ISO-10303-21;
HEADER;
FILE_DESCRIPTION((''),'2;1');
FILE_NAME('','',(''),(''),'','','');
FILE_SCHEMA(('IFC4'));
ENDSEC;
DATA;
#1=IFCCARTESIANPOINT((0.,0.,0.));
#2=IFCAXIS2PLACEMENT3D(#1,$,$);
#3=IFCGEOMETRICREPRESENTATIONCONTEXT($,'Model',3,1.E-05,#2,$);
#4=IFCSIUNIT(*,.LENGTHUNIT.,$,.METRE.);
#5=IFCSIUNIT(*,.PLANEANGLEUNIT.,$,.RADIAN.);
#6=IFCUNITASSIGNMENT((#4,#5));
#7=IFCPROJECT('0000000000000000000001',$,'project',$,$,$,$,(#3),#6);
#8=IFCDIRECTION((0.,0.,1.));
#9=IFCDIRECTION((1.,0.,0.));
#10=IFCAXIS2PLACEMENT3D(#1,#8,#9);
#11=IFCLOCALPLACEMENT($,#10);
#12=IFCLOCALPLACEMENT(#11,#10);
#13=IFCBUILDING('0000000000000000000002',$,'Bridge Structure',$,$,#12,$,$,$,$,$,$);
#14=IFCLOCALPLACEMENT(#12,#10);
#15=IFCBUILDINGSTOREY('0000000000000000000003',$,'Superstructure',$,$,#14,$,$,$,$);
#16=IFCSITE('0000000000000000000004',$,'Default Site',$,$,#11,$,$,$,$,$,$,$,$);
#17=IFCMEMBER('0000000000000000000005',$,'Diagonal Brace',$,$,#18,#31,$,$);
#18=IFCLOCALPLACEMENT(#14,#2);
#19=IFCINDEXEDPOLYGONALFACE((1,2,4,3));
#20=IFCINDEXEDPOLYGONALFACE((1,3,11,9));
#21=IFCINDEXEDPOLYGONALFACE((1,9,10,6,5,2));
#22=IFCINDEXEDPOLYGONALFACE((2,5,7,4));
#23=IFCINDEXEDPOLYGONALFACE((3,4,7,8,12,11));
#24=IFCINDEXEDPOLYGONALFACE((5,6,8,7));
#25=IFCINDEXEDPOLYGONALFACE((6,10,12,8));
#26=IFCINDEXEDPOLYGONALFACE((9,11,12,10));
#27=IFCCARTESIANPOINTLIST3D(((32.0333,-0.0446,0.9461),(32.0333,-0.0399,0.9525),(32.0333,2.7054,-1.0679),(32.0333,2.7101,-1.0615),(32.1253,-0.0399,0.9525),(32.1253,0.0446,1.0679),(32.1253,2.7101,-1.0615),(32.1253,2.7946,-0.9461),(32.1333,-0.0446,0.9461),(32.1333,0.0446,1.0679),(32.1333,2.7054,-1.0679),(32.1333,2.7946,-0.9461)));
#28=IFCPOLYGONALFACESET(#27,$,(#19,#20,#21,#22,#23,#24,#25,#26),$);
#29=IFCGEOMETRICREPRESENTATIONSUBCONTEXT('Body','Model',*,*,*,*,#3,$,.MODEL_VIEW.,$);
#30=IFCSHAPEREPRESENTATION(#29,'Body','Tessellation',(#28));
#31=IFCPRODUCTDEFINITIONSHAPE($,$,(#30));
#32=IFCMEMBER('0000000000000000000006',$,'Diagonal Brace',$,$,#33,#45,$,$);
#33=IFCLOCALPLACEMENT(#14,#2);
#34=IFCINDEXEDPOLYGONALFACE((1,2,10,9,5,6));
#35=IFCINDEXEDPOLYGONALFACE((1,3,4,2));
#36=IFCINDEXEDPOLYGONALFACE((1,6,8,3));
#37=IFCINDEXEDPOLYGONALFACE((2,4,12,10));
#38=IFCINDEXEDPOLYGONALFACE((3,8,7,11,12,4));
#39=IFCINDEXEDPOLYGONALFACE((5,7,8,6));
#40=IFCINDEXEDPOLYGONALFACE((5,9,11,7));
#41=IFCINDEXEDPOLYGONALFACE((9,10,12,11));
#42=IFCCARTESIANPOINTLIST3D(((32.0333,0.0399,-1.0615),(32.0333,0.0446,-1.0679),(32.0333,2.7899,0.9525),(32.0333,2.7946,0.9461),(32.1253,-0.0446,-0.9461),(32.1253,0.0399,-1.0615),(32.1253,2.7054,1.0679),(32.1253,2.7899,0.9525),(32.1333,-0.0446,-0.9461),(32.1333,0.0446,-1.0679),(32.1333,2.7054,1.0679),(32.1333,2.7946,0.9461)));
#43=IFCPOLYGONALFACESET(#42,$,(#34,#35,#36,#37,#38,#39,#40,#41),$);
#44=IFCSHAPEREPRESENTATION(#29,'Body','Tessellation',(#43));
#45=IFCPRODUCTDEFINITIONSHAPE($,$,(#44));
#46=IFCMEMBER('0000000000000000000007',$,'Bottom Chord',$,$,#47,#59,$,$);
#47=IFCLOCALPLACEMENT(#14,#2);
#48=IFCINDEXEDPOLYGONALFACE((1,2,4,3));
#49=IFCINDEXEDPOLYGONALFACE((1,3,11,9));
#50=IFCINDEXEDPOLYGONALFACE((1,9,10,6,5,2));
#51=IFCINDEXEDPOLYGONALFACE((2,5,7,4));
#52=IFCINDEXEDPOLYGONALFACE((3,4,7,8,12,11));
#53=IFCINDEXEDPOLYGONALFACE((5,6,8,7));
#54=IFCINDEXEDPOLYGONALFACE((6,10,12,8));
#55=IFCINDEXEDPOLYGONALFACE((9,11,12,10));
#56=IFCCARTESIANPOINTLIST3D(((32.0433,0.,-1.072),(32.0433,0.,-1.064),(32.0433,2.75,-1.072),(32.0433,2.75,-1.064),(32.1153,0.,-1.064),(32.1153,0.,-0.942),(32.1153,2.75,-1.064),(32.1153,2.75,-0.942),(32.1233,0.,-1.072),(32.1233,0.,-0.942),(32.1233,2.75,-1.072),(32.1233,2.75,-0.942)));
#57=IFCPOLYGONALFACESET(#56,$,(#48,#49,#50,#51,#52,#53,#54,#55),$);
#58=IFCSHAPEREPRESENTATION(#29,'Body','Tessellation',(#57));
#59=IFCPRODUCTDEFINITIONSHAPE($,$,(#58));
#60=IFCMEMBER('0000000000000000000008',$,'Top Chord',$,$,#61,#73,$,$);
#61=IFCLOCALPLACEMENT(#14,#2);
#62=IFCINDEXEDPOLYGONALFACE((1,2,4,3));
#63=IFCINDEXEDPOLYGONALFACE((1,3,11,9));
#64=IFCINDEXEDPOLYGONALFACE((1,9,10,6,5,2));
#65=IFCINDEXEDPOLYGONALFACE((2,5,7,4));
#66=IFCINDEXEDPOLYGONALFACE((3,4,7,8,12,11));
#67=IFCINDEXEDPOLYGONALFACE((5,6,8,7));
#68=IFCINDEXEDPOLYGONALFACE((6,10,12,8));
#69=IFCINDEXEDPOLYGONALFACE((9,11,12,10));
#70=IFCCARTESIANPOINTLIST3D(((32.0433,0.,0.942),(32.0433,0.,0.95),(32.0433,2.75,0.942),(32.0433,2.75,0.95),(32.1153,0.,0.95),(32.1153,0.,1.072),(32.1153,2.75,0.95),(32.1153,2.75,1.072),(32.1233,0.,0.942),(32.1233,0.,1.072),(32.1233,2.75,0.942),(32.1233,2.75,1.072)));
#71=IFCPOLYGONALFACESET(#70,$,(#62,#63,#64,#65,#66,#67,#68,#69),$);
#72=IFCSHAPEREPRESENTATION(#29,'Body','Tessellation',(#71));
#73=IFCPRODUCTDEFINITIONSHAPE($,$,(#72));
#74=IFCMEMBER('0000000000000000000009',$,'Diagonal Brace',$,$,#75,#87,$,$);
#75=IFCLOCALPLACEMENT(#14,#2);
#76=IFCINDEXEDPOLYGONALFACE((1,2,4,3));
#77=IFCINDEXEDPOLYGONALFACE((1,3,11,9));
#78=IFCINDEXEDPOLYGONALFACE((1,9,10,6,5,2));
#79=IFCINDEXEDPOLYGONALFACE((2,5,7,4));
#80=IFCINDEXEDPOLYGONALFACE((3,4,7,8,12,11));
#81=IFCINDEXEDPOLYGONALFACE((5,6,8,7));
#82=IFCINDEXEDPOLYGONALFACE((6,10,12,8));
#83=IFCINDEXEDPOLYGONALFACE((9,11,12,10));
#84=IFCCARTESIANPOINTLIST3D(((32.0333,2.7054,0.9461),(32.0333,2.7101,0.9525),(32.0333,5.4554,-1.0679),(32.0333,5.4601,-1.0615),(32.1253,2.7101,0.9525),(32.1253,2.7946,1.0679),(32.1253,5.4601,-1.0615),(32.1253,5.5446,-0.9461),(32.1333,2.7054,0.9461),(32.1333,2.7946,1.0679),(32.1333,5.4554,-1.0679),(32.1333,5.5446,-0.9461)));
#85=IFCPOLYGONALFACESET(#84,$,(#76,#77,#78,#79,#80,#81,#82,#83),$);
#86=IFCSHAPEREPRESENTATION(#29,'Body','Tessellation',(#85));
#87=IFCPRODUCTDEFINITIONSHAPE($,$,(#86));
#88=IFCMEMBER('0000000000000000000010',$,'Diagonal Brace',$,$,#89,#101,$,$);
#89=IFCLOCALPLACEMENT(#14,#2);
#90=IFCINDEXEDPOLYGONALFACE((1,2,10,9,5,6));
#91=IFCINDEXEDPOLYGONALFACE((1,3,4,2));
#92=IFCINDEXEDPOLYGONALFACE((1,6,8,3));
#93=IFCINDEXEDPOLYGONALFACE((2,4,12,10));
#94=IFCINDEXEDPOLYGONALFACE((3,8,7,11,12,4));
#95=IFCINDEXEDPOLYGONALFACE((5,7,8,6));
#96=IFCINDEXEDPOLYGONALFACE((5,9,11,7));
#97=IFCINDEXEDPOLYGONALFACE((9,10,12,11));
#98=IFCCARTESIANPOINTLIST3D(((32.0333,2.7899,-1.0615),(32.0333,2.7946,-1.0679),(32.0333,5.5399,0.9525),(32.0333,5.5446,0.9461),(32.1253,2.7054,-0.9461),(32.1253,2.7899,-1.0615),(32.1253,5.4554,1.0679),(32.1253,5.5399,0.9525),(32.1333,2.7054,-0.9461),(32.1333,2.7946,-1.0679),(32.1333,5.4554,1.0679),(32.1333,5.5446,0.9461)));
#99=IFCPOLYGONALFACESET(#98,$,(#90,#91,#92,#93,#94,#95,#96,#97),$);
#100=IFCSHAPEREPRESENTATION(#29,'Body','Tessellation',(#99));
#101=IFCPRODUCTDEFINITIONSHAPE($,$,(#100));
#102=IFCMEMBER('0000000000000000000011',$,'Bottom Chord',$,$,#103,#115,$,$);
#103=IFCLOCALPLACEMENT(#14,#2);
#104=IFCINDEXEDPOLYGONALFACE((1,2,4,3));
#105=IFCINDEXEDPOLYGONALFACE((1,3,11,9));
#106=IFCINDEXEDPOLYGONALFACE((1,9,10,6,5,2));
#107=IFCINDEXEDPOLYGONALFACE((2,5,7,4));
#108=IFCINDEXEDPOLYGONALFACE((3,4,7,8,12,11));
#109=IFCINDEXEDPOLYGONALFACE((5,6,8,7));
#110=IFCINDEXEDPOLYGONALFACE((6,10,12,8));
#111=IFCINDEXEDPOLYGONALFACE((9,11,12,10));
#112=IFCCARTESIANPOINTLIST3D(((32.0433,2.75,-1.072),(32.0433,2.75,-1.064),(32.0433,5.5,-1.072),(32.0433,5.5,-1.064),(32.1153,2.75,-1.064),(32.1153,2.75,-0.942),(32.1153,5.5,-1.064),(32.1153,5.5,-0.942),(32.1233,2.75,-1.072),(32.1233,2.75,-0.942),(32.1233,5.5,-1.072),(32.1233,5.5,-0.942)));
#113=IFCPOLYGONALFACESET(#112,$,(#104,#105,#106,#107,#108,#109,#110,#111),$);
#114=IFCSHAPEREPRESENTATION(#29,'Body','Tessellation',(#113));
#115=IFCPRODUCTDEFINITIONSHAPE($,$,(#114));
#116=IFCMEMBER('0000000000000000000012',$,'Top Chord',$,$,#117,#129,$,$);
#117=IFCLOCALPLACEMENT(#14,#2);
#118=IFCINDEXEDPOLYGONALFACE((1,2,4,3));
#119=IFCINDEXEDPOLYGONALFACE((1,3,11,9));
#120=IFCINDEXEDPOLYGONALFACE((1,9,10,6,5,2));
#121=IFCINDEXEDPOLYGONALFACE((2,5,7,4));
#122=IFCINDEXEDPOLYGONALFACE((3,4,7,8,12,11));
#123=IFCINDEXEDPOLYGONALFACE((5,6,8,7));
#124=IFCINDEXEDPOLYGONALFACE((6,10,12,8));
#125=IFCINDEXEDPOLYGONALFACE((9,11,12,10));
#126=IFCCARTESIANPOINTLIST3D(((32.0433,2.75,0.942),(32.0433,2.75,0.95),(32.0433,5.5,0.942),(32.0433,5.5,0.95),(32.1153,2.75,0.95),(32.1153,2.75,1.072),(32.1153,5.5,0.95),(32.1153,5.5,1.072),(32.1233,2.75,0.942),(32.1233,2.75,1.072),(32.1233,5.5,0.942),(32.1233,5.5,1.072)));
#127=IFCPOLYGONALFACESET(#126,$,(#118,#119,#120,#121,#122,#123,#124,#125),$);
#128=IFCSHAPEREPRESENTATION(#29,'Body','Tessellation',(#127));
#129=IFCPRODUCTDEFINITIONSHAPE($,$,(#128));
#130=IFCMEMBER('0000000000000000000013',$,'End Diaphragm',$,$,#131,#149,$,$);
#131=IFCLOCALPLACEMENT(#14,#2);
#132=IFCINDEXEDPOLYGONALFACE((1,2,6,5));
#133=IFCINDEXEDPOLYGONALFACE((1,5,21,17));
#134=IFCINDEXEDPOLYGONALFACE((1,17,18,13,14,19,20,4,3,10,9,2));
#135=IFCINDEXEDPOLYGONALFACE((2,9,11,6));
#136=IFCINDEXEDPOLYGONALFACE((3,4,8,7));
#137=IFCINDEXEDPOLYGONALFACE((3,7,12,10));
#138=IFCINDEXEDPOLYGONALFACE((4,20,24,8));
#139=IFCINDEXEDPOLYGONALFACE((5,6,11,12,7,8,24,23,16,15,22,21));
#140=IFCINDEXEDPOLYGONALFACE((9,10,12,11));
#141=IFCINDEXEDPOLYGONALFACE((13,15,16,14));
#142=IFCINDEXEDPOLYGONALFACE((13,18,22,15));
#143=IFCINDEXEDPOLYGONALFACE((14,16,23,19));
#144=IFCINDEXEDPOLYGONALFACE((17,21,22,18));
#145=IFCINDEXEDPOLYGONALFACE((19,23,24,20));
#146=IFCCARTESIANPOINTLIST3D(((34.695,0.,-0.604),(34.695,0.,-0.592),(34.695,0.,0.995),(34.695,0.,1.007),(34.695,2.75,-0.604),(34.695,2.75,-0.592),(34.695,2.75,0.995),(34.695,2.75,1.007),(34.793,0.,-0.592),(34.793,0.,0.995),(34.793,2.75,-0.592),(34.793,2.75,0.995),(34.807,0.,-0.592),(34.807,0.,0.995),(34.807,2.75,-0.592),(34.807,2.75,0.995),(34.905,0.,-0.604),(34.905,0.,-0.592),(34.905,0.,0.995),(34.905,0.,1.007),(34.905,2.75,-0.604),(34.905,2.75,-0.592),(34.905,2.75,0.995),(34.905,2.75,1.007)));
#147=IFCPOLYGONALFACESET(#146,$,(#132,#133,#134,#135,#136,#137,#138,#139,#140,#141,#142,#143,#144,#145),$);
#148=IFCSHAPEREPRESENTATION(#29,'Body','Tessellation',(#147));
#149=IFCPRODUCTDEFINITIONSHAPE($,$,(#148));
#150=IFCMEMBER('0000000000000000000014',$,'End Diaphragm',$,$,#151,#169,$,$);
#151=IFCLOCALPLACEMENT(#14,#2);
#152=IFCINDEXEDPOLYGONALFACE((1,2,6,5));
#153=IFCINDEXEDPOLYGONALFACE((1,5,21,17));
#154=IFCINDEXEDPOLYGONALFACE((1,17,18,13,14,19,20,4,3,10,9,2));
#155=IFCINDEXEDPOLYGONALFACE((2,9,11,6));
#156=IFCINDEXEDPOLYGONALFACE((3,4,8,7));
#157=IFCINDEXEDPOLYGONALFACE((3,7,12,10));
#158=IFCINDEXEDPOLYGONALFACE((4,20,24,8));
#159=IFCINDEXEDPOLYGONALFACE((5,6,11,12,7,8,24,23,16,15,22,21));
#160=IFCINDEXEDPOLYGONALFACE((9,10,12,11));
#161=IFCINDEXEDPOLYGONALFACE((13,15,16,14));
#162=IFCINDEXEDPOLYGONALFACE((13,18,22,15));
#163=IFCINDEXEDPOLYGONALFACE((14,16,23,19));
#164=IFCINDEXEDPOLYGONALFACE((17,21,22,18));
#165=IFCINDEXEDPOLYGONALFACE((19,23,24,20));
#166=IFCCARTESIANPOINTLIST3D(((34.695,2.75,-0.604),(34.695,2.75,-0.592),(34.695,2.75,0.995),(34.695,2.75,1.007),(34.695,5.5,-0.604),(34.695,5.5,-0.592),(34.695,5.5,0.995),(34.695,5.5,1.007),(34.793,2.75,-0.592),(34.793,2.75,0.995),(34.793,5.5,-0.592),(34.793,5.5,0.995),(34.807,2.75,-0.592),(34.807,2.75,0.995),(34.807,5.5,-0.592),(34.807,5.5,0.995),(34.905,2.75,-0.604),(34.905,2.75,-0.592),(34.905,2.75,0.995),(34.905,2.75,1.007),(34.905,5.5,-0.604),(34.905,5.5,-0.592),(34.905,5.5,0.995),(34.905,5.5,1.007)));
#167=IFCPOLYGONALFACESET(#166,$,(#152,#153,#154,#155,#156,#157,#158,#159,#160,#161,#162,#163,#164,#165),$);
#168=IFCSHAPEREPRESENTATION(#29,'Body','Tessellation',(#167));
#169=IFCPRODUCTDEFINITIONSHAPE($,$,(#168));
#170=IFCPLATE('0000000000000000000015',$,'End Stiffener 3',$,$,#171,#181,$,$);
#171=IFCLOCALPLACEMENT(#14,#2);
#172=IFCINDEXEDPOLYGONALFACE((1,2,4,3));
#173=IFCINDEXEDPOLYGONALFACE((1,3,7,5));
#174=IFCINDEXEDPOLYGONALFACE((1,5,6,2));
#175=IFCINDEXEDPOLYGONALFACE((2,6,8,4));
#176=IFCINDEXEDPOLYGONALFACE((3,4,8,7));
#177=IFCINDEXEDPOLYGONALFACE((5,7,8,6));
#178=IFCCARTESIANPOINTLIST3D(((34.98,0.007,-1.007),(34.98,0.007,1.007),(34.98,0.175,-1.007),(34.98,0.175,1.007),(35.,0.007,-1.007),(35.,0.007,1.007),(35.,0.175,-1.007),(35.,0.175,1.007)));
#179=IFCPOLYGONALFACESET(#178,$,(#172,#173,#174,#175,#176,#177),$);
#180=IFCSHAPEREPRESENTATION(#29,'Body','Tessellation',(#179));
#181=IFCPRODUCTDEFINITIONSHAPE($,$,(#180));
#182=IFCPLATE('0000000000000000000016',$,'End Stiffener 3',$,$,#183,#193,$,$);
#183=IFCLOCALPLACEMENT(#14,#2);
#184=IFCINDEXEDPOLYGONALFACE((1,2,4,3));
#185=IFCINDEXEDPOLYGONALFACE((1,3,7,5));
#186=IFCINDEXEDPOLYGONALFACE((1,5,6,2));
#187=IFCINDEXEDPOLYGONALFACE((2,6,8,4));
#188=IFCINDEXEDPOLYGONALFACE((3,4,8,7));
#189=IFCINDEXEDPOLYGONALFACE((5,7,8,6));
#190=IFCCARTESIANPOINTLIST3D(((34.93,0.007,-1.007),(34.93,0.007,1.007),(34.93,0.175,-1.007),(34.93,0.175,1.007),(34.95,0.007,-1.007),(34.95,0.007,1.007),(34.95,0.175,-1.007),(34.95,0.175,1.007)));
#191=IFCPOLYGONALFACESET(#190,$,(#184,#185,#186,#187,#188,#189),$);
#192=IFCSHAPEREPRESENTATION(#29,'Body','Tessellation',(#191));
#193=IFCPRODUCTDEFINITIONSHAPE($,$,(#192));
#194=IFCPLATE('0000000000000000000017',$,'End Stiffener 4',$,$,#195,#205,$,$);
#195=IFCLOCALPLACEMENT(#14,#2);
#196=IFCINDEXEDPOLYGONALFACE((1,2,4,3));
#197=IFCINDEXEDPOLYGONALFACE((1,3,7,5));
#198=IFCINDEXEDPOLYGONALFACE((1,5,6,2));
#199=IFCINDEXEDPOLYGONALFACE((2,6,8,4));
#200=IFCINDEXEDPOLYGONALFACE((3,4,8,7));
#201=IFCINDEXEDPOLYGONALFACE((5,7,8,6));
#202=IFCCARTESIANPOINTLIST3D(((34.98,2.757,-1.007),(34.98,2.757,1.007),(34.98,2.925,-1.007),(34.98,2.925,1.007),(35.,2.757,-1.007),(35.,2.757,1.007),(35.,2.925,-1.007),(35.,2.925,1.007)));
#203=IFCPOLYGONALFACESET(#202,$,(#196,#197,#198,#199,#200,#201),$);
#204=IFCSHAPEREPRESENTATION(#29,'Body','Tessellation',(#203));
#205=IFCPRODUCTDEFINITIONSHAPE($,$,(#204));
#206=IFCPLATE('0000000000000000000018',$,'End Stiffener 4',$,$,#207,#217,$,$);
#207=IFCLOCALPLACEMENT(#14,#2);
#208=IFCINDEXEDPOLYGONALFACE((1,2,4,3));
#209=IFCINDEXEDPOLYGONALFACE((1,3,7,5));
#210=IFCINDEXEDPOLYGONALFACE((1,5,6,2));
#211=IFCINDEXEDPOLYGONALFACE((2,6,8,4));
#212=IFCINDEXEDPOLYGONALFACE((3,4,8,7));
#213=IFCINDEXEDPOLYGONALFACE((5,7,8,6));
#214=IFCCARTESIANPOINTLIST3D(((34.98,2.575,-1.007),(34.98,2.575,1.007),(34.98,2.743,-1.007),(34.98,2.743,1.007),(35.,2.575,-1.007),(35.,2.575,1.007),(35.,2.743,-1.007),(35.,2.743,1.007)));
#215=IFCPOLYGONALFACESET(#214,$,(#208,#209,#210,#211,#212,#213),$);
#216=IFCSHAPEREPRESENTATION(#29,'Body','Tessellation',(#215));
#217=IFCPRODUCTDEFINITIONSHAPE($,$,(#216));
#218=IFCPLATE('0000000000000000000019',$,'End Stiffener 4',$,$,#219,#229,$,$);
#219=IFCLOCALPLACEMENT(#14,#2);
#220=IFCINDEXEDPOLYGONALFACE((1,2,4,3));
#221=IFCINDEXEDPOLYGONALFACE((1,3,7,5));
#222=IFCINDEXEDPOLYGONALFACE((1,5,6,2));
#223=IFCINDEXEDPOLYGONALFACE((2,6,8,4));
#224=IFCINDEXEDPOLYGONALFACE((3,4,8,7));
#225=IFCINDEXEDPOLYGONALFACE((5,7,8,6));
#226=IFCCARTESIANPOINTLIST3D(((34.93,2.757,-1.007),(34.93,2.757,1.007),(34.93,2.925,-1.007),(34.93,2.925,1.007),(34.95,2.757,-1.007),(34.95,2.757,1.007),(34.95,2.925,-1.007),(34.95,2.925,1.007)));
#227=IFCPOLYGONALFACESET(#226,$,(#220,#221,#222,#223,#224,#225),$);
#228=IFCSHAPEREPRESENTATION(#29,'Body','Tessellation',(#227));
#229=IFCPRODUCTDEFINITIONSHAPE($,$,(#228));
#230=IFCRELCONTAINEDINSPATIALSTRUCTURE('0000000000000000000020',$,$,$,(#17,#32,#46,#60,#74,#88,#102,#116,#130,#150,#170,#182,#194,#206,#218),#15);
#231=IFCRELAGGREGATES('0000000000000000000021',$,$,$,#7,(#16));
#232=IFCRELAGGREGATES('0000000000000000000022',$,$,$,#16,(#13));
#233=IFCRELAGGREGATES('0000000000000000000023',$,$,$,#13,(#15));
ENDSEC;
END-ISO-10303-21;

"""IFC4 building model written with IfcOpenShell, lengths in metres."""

from ifc_helpers import new_model, si_unit, frame, origin, origin_with_axes, origin_2d_with_axis, place, context, subcontext, project, spatial, rectangle, i_section, l_section, extrude, element, save


model = new_model("IFC4")

# Units and contexts
model_context = context("Model", 3, precision=1e-05, world=origin())
body_context = subcontext(model_context, "Body", "Model", "MODEL_VIEW")
ifc_project = project(units=[si_unit("LENGTHUNIT", "METRE"), si_unit("PLANEANGLEUNIT", "RADIAN")], contexts=[model_context])

# Site, building, storey
site_placement = place(None, origin_with_axes())
site = spatial("IfcSite", under=ifc_project, at=site_placement, Name="Default Site")
building_placement = place(site_placement, origin_with_axes())
building = spatial("IfcBuilding", under=site, at=building_placement, Name="Bridge Structure")
storey_placement = place(building_placement, origin_with_axes())
storey = spatial("IfcBuildingStorey", under=building, at=storey_placement, Name="Superstructure")

# Members
for number, where, z_axis, x_axis, name in (
    (1, (32.0833, 0.0, 1.007), (0.0, 0.806778, -0.590855), (-1.0, 0.0, 0.0), "Diagonal Brace"),
    (2, (32.0833, 0.0, -1.007), (0.0, 0.806778, 0.590855), (-1.0, 0.0, 0.0), "Diagonal Brace"),
):
    element("IfcMember", number, at=place(storey_placement, frame(where, z_axis=z_axis, x_axis=x_axis)), inside=storey, Name=name, context=body_context, shape_type="SweptSolid", body=[
        extrude(l_section(Depth=0.151, Width=0.1, Thickness=0.008, at=origin_2d_with_axis()), origin_with_axes(), (0.0, 0.0, 1.0), 3.4086),
    ])
for number, where, z_axis, x_axis, name in (
    (3, (32.0833, 0.0, -1.007), (0.0, 1.0, 0.0), (-1.0, 0.0, 0.0), "Bottom Chord"),
    (4, (32.0833, 0.0, 1.007), (0.0, 1.0, 0.0), (-1.0, 0.0, 0.0), "Top Chord"),
):
    element("IfcMember", number, at=place(storey_placement, frame(where, z_axis=z_axis, x_axis=x_axis)), inside=storey, Name=name, context=body_context, shape_type="SweptSolid", body=[
        extrude(l_section(Depth=0.13, Width=0.08, Thickness=0.008, at=origin_2d_with_axis()), origin_with_axes(), (0.0, 0.0, 1.0), 2.75),
    ])
for number, where, z_axis, x_axis, name in (
    (5, (32.0833, 2.75, 1.007), (0.0, 0.806778, -0.590855), (-1.0, 0.0, 0.0), "Diagonal Brace"),
    (6, (32.0833, 2.75, -1.007), (0.0, 0.806778, 0.590855), (-1.0, 0.0, 0.0), "Diagonal Brace"),
):
    element("IfcMember", number, at=place(storey_placement, frame(where, z_axis=z_axis, x_axis=x_axis)), inside=storey, Name=name, context=body_context, shape_type="SweptSolid", body=[
        extrude(l_section(Depth=0.151, Width=0.1, Thickness=0.008, at=origin_2d_with_axis()), origin_with_axes(), (0.0, 0.0, 1.0), 3.4086),
    ])
for number, where, z_axis, x_axis, name in (
    (7, (32.0833, 2.75, -1.007), (0.0, 1.0, 0.0), (-1.0, 0.0, 0.0), "Bottom Chord"),
    (8, (32.0833, 2.75, 1.007), (0.0, 1.0, 0.0), (-1.0, 0.0, 0.0), "Top Chord"),
):
    element("IfcMember", number, at=place(storey_placement, frame(where, z_axis=z_axis, x_axis=x_axis)), inside=storey, Name=name, context=body_context, shape_type="SweptSolid", body=[
        extrude(l_section(Depth=0.13, Width=0.08, Thickness=0.008, at=origin_2d_with_axis()), origin_with_axes(), (0.0, 0.0, 1.0), 2.75),
    ])
for number, where, z_axis, x_axis, name in (
    (9, (34.8, 0.0, 0.2015), (0.0, 1.0, 0.0), (-1.0, 0.0, 0.0), "End Diaphragm"),
    (10, (34.8, 2.75, 0.2015), (0.0, 1.0, 0.0), (-1.0, 0.0, 0.0), "End Diaphragm"),
):
    element("IfcMember", number, at=place(storey_placement, frame(where, z_axis=z_axis, x_axis=x_axis)), inside=storey, Name=name, context=body_context, shape_type="SweptSolid", body=[
        extrude(i_section(OverallWidth=0.21, OverallDepth=1.611, WebThickness=0.014, FlangeThickness=0.012, at=origin_2d_with_axis()), origin_with_axes(), (0.0, 0.0, 1.0), 2.75),
    ])

# Plates
for number, where, z_axis, x_axis, name in (
    (11, (34.99, 0.091, -1.007), (0.0, 0.0, 1.0), (1.0, 0.0, 0.0), "End Stiffener 3"),
    (12, (34.94, 0.091, -1.007), (0.0, 0.0, 1.0), (1.0, 0.0, 0.0), "End Stiffener 3"),
    (13, (34.99, 2.841, -1.007), (0.0, 0.0, 1.0), (1.0, 0.0, 0.0), "End Stiffener 4"),
    (14, (34.99, 2.659, -1.007), (0.0, 0.0, 1.0), (1.0, 0.0, 0.0), "End Stiffener 4"),
    (15, (34.94, 2.841, -1.007), (0.0, 0.0, 1.0), (1.0, 0.0, 0.0), "End Stiffener 4"),
):
    element("IfcPlate", number, at=place(storey_placement, frame(where, z_axis=z_axis, x_axis=x_axis)), inside=storey, Name=name, context=body_context, shape_type="SweptSolid", body=[
        extrude(rectangle(XDim=0.02, YDim=0.168, at=origin_2d_with_axis()), origin_with_axes(), (0.0, 0.0, 1.0), 2.014),
    ])

save(model, "model.ifc")
